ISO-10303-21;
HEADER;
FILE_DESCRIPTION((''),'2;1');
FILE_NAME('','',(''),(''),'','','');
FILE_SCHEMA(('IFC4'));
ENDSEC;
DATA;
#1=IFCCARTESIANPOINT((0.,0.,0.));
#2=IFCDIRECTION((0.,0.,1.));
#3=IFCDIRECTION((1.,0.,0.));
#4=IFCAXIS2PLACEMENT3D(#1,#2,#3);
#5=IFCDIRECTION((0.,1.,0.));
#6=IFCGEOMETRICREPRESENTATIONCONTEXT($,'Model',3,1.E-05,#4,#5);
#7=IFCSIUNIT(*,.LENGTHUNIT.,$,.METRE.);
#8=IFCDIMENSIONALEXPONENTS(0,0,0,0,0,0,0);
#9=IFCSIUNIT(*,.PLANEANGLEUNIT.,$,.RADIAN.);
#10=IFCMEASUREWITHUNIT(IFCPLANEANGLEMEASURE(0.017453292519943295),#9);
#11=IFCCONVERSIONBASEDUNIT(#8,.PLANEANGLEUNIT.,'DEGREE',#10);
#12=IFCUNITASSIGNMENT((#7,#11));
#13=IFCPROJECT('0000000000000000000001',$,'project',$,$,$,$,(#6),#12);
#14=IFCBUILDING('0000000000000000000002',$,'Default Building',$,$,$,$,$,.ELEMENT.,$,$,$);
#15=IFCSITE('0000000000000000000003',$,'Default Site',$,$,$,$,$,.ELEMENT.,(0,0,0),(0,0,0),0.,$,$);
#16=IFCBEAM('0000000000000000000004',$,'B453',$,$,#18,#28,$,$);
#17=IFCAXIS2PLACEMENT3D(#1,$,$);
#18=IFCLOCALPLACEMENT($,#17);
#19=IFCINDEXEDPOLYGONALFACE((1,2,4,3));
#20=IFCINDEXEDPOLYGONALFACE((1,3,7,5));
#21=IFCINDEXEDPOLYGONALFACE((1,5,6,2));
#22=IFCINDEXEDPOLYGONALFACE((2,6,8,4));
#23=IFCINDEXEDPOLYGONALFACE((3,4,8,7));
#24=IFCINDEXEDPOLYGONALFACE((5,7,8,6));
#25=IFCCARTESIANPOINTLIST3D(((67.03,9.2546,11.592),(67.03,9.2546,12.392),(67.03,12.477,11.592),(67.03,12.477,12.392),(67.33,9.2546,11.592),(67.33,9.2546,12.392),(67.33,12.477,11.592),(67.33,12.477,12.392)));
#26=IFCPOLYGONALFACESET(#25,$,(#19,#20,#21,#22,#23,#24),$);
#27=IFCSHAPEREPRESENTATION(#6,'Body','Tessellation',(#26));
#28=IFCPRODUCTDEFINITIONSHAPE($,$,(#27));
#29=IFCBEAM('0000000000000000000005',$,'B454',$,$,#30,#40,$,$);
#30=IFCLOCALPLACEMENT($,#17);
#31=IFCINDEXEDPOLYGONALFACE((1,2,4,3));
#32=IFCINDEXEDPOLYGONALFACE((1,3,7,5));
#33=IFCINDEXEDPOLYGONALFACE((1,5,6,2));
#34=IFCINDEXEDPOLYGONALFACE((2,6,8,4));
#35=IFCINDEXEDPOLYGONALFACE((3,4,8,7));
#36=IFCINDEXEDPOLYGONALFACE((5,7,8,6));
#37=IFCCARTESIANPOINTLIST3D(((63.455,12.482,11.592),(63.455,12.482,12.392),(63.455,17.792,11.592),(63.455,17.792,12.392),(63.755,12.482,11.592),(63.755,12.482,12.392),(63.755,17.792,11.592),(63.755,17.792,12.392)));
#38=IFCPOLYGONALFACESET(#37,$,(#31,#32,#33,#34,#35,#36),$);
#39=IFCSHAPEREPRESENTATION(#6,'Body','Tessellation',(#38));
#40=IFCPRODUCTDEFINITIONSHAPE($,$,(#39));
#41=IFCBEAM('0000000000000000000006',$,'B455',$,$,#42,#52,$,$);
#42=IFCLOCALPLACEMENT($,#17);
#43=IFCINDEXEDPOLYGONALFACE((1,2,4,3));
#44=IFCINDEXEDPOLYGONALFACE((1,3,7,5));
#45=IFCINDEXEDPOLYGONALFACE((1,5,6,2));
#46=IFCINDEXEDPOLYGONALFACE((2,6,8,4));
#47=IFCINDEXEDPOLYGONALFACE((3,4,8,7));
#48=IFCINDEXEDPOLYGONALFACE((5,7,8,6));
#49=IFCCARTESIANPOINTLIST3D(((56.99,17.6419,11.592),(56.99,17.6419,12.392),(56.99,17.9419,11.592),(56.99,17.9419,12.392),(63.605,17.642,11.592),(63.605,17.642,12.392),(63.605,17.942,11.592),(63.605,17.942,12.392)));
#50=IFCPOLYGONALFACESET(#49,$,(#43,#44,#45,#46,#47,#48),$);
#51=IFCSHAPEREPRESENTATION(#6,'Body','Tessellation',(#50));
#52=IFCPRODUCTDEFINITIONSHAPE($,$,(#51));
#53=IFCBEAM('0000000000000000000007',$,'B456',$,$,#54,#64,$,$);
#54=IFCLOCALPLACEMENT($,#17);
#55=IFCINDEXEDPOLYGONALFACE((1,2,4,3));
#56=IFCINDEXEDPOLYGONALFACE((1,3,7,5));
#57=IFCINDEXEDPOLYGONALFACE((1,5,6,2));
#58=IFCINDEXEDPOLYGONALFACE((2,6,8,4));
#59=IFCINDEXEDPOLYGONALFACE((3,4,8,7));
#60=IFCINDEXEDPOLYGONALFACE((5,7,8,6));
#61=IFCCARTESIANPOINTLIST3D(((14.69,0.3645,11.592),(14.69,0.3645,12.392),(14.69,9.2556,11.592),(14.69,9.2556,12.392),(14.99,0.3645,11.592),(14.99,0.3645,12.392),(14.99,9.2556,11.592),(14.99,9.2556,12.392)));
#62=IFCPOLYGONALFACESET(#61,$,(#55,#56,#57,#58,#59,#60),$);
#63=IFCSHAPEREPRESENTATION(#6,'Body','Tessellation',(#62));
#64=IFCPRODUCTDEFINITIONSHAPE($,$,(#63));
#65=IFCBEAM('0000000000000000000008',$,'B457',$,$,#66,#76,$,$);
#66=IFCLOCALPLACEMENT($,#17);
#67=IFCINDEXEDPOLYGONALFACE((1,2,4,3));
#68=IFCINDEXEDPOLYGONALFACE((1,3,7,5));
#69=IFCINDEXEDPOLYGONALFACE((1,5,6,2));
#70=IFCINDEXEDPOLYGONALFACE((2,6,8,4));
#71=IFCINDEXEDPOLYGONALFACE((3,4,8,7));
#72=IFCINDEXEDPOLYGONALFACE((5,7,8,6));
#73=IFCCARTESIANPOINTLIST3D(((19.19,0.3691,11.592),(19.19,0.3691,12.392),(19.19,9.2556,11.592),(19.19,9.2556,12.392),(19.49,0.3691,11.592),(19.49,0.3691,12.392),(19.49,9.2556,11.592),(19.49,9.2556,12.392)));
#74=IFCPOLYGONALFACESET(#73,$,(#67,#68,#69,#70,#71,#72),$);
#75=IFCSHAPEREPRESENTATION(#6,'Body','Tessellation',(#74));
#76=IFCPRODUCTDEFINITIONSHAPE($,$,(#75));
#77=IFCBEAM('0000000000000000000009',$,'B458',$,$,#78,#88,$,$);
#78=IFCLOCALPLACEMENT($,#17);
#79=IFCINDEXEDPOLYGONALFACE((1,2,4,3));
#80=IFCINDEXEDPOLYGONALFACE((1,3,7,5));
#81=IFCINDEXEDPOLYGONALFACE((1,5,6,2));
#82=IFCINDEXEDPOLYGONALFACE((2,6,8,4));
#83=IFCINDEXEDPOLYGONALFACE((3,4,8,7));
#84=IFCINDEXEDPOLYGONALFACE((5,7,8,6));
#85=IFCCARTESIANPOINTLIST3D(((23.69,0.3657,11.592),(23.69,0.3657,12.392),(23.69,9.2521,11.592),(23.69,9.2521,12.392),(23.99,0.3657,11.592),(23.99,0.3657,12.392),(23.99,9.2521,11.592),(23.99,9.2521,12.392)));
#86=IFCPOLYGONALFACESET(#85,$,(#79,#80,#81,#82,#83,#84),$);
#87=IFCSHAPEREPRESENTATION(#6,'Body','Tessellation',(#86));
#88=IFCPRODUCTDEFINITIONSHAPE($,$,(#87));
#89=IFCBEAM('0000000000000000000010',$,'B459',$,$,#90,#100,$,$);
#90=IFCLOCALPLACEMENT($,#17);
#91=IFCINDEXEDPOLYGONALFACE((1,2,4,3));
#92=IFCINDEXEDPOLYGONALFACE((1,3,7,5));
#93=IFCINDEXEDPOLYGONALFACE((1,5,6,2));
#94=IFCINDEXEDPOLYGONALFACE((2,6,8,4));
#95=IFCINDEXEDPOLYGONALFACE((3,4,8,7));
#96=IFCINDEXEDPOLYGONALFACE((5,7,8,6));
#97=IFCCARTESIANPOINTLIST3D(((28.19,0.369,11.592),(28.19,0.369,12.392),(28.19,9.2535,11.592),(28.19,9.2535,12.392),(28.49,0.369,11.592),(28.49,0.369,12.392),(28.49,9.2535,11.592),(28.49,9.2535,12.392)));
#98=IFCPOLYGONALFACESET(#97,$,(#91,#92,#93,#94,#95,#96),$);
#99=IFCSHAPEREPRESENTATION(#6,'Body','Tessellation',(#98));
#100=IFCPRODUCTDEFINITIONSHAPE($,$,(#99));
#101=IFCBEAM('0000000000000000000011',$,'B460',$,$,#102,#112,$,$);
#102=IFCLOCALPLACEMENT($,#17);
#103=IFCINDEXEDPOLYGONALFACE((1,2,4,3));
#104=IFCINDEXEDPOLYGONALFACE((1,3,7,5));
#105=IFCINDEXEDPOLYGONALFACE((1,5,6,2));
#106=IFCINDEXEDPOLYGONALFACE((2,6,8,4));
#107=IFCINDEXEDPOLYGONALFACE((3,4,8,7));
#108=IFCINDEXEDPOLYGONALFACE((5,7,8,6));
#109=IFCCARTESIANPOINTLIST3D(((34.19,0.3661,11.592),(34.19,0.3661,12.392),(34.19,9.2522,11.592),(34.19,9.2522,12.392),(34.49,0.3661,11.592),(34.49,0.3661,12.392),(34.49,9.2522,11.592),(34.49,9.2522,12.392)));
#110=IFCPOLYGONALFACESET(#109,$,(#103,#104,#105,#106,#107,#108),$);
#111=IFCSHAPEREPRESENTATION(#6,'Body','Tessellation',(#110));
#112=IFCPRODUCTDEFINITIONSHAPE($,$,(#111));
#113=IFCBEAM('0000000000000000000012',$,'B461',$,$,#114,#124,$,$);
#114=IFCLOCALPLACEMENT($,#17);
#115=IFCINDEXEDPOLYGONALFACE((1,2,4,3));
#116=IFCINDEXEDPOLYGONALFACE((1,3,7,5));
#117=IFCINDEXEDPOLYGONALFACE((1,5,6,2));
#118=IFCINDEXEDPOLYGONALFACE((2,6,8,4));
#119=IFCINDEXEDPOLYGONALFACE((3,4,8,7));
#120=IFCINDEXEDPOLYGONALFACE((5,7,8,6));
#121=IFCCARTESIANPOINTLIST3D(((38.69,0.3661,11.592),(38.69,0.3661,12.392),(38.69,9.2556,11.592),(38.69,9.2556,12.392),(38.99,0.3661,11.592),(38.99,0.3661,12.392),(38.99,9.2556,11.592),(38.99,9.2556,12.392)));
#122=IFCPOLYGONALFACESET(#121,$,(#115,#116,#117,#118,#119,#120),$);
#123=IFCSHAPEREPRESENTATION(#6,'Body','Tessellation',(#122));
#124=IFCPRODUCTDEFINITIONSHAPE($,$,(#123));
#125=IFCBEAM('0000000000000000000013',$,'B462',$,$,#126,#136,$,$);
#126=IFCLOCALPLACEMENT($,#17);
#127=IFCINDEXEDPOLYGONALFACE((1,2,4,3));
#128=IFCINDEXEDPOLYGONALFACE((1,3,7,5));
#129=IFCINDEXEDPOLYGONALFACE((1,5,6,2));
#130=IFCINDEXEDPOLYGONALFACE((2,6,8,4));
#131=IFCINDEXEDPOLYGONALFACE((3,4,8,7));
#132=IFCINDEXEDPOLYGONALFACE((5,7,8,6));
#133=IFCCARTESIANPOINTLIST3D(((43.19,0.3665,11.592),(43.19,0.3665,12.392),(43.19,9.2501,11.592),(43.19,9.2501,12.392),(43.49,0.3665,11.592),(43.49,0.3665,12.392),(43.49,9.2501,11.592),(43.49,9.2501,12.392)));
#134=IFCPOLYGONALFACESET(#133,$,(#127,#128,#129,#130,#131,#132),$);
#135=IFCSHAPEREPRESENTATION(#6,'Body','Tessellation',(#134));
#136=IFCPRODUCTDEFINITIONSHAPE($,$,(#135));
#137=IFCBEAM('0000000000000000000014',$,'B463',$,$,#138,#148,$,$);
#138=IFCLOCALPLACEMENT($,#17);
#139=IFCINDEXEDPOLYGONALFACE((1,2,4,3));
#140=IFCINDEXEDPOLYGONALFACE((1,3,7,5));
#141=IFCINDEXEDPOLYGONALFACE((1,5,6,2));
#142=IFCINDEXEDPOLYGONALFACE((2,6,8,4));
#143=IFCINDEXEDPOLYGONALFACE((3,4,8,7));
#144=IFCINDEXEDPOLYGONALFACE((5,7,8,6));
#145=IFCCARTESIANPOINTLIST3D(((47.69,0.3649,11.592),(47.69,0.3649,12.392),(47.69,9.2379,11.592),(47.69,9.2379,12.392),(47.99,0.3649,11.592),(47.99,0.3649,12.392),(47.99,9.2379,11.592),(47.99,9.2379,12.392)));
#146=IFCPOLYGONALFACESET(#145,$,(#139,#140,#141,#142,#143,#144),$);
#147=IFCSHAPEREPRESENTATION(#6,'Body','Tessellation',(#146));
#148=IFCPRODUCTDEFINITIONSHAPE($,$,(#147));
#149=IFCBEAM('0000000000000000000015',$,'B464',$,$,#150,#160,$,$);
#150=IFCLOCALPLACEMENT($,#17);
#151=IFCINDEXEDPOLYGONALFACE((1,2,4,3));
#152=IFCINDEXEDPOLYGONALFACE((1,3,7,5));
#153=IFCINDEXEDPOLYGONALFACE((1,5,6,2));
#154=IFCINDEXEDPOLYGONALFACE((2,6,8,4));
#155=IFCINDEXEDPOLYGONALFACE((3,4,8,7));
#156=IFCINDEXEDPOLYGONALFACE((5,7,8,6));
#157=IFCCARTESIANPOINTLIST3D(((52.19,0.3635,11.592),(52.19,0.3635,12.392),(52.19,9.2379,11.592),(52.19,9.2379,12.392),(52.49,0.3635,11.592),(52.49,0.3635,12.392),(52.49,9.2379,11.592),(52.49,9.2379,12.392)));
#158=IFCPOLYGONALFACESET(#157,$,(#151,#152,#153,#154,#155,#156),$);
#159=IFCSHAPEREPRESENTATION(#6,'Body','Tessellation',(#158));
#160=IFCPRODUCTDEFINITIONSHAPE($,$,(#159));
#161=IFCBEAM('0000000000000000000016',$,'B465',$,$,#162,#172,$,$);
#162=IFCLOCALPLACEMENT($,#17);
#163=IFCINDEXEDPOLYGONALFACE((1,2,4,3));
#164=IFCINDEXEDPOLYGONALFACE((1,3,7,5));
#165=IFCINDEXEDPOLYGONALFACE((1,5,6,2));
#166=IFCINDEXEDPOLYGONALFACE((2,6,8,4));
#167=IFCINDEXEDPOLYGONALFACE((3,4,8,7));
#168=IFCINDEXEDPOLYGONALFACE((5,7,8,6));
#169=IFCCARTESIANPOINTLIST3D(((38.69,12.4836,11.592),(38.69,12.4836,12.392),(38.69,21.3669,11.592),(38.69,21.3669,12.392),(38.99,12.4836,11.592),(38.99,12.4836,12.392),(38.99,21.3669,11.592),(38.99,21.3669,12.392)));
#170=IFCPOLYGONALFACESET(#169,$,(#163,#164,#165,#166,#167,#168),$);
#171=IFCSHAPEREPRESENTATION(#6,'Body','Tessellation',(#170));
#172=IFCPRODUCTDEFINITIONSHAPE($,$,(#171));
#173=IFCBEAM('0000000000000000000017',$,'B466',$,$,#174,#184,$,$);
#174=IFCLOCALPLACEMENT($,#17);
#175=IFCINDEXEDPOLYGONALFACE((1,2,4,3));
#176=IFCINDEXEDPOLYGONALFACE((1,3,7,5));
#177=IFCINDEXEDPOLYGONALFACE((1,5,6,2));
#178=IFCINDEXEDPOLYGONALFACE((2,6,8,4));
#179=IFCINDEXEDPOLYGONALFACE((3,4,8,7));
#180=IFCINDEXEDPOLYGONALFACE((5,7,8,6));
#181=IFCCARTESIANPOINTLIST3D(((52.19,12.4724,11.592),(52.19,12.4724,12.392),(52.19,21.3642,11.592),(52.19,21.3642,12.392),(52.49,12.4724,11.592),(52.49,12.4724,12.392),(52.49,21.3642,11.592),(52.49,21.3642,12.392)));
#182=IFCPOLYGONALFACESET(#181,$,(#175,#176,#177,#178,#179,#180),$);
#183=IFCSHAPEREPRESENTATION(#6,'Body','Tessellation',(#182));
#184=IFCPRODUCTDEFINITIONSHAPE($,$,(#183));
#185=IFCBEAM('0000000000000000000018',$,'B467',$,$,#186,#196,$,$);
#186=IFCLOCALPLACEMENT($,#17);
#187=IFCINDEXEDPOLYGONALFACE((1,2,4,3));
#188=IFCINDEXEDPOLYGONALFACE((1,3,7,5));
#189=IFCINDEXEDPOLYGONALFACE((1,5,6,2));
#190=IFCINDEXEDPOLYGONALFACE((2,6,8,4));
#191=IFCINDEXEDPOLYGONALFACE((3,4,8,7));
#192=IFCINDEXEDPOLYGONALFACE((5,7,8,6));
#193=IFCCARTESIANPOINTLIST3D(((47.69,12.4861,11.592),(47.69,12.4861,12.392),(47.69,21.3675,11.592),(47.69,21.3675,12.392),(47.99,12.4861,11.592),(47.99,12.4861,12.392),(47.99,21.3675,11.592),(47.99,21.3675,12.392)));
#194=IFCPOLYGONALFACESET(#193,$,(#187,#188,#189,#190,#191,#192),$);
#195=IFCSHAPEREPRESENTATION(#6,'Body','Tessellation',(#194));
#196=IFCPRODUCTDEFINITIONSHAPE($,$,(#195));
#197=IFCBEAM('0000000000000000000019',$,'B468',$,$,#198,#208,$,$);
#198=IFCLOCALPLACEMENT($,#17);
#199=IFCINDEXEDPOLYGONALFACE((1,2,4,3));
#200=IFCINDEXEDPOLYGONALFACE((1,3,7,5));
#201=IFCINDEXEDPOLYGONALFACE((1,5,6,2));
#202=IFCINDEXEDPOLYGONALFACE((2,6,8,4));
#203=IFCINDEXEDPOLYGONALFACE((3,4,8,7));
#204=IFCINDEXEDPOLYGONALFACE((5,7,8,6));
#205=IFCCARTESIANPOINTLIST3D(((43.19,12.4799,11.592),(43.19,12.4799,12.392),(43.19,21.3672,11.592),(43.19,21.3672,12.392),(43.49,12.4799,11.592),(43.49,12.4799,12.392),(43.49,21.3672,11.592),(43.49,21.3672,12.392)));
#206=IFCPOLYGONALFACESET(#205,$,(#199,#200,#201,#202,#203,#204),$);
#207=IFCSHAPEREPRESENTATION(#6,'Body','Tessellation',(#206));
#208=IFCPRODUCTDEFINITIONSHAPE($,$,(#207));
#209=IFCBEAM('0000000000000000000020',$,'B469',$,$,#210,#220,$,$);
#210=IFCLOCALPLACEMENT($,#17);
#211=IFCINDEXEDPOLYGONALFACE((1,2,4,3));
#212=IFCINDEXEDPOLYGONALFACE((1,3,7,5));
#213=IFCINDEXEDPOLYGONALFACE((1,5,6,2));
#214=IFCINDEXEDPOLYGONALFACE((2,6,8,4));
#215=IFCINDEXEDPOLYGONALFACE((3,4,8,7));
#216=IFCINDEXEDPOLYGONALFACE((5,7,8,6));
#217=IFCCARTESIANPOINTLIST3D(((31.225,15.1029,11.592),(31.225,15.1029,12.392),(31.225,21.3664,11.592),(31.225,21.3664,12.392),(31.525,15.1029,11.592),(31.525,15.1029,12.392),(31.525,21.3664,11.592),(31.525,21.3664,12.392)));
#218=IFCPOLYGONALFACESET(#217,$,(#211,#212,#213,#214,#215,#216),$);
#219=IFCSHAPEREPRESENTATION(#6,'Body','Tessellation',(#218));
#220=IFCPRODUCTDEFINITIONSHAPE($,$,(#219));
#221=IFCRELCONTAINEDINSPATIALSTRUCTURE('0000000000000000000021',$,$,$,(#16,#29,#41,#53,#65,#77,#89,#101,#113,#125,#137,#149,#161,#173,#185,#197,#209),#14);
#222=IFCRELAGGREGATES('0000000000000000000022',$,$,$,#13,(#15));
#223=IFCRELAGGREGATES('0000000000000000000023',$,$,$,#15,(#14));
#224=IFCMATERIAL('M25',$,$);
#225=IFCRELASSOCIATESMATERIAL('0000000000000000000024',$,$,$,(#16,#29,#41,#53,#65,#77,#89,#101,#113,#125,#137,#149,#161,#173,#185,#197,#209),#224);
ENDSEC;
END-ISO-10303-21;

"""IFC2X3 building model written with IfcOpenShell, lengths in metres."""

from ifc_helpers import new_model, entity, si_unit, converted_unit, direction, frame, frame_2d, origin_with_axes, place, context, project, spatial, rectangle, extrude, material, element, save


model = new_model("IFC2X3")

# Units and contexts
model_context = context("Model", 3, precision=1e-05, world=origin_with_axes(), true_north=direction((0.0, 1.0, 0.0)))
ifc_project = project(units=[si_unit("LENGTHUNIT", "METRE"), converted_unit("PLANEANGLEUNIT", "DEGREE", entity("IfcPlaneAngleMeasure", 0.017453292519943295), si_unit("PLANEANGLEUNIT", "RADIAN"), dimensions=[0, 0, 0, 0, 0, 0, 0])], contexts=[model_context])

# Site, building
site = spatial("IfcSite", under=ifc_project, Name="Default Site", CompositionType="ELEMENT", RefLatitude=(0, 0, 0), RefLongitude=(0, 0, 0), RefElevation=0.0)
building = spatial("IfcBuilding", under=site, Name="Default Building", CompositionType="ELEMENT")

# Beams
ifc_material = material(Name="M25")
placement = place(None, origin_with_axes())
element("IfcBeam", 1, at=placement, inside=building, material=ifc_material, Name="B453", context=model_context, shape_type="SweptSolid", body=[
    extrude(rectangle(XDim=0.3, YDim=0.8, at=frame_2d((0.0, 0.0), x_axis=(0.0, 1.0, 0.0))), frame((67.18, 9.2546, 11.992), z_axis=(0.0, 1.0, 0.0), x_axis=(0.0, 0.0, -1.0)), (0.0, 0.0, 1.0), 3.2224),
])
element("IfcBeam", 2, at=placement, inside=building, material=ifc_material, Name="B454", context=model_context, shape_type="SweptSolid", body=[
    extrude(rectangle(XDim=0.3, YDim=0.8, at=frame_2d((0.0, 0.0), x_axis=(0.0, 1.0, 0.0))), frame((63.605, 12.482, 11.992), z_axis=(0.0, 1.0, 0.0), x_axis=(0.0, 0.0, -1.0)), (0.0, 0.0, 1.0), 5.3101),
])
element("IfcBeam", 3, at=placement, inside=building, material=ifc_material, Name="B455", context=model_context, shape_type="SweptSolid", body=[
    extrude(rectangle(XDim=0.3, YDim=0.8, at=frame_2d((0.0, 0.0), x_axis=(0.0, 1.0, 0.0))), frame((56.99, 17.7919, 11.992), z_axis=(1.0, 0.00002, 0.0), x_axis=(0.0, 0.0, -1.0)), (0.0, 0.0, 1.0), 6.615),
])
element("IfcBeam", 4, at=placement, inside=building, material=ifc_material, Name="B456", context=model_context, shape_type="SweptSolid", body=[
    extrude(rectangle(XDim=0.3, YDim=0.8, at=frame_2d((0.0, 0.0), x_axis=(0.0, 1.0, 0.0))), frame((14.84, 0.3645, 11.992), z_axis=(0.0, 1.0, 0.0), x_axis=(0.0, 0.0, -1.0)), (0.0, 0.0, 1.0), 8.891),
])
element("IfcBeam", 5, at=placement, inside=building, material=ifc_material, Name="B457", context=model_context, shape_type="SweptSolid", body=[
    extrude(rectangle(XDim=0.3, YDim=0.8, at=frame_2d((0.0, 0.0), x_axis=(0.0, 1.0, 0.0))), frame((19.34, 0.3691, 11.992), z_axis=(0.0, 1.0, 0.0), x_axis=(0.0, 0.0, -1.0)), (0.0, 0.0, 1.0), 8.8865),
])
element("IfcBeam", 6, at=placement, inside=building, material=ifc_material, Name="B458", context=model_context, shape_type="SweptSolid", body=[
    extrude(rectangle(XDim=0.3, YDim=0.8, at=frame_2d((0.0, 0.0), x_axis=(0.0, 1.0, 0.0))), frame((23.84, 0.3657, 11.992), z_axis=(0.0, 1.0, 0.0), x_axis=(0.0, 0.0, -1.0)), (0.0, 0.0, 1.0), 8.8864),
])
element("IfcBeam", 7, at=placement, inside=building, material=ifc_material, Name="B459", context=model_context, shape_type="SweptSolid", body=[
    extrude(rectangle(XDim=0.3, YDim=0.8, at=frame_2d((0.0, 0.0), x_axis=(0.0, 1.0, 0.0))), frame((28.34, 0.369, 11.992), z_axis=(0.0, 1.0, 0.0), x_axis=(0.0, 0.0, -1.0)), (0.0, 0.0, 1.0), 8.8845),
])
element("IfcBeam", 8, at=placement, inside=building, material=ifc_material, Name="B460", context=model_context, shape_type="SweptSolid", body=[
    extrude(rectangle(XDim=0.3, YDim=0.8, at=frame_2d((0.0, 0.0), x_axis=(0.0, 1.0, 0.0))), frame((34.34, 0.3661, 11.992), z_axis=(0.0, 1.0, 0.0), x_axis=(0.0, 0.0, -1.0)), (0.0, 0.0, 1.0), 8.8861),
])
element("IfcBeam", 9, at=placement, inside=building, material=ifc_material, Name="B461", context=model_context, shape_type="SweptSolid", body=[
    extrude(rectangle(XDim=0.3, YDim=0.8, at=frame_2d((0.0, 0.0), x_axis=(0.0, 1.0, 0.0))), frame((38.84, 0.3661, 11.992), z_axis=(0.0, 1.0, 0.0), x_axis=(0.0, 0.0, -1.0)), (0.0, 0.0, 1.0), 8.8895),
])
element("IfcBeam", 10, at=placement, inside=building, material=ifc_material, Name="B462", context=model_context, shape_type="SweptSolid", body=[
    extrude(rectangle(XDim=0.3, YDim=0.8, at=frame_2d((0.0, 0.0), x_axis=(0.0, 1.0, 0.0))), frame((43.34, 0.3665, 11.992), z_axis=(0.0, 1.0, 0.0), x_axis=(0.0, 0.0, -1.0)), (0.0, 0.0, 1.0), 8.8836),
])
element("IfcBeam", 11, at=placement, inside=building, material=ifc_material, Name="B463", context=model_context, shape_type="SweptSolid", body=[
    extrude(rectangle(XDim=0.3, YDim=0.8, at=frame_2d((0.0, 0.0), x_axis=(0.0, 1.0, 0.0))), frame((47.84, 0.3649, 11.992), z_axis=(0.0, 1.0, 0.0), x_axis=(0.0, 0.0, -1.0)), (0.0, 0.0, 1.0), 8.873),
])
element("IfcBeam", 12, at=placement, inside=building, material=ifc_material, Name="B464", context=model_context, shape_type="SweptSolid", body=[
    extrude(rectangle(XDim=0.3, YDim=0.8, at=frame_2d((0.0, 0.0), x_axis=(0.0, 1.0, 0.0))), frame((52.34, 0.3635, 11.992), z_axis=(0.0, 1.0, 0.0), x_axis=(0.0, 0.0, -1.0)), (0.0, 0.0, 1.0), 8.8744),
])
element("IfcBeam", 13, at=placement, inside=building, material=ifc_material, Name="B465", context=model_context, shape_type="SweptSolid", body=[
    extrude(rectangle(XDim=0.3, YDim=0.8, at=frame_2d((0.0, 0.0), x_axis=(0.0, 1.0, 0.0))), frame((38.84, 21.3669, 11.992), z_axis=(0.0, -1.0, 0.0), x_axis=(0.0, 0.0, -1.0)), (0.0, 0.0, 1.0), 8.8833),
])
element("IfcBeam", 14, at=placement, inside=building, material=ifc_material, Name="B466", context=model_context, shape_type="SweptSolid", body=[
    extrude(rectangle(XDim=0.3, YDim=0.8, at=frame_2d((0.0, 0.0), x_axis=(0.0, 1.0, 0.0))), frame((52.34, 12.4724, 11.992), z_axis=(0.0, 1.0, 0.0), x_axis=(0.0, 0.0, -1.0)), (0.0, 0.0, 1.0), 8.8918),
])
element("IfcBeam", 15, at=placement, inside=building, material=ifc_material, Name="B467", context=model_context, shape_type="SweptSolid", body=[
    extrude(rectangle(XDim=0.3, YDim=0.8, at=frame_2d((0.0, 0.0), x_axis=(0.0, 1.0, 0.0))), frame((47.84, 12.4861, 11.992), z_axis=(0.0, 1.0, 0.0), x_axis=(0.0, 0.0, -1.0)), (0.0, 0.0, 1.0), 8.8814),
])
element("IfcBeam", 16, at=placement, inside=building, material=ifc_material, Name="B468", context=model_context, shape_type="SweptSolid", body=[
    extrude(rectangle(XDim=0.3, YDim=0.8, at=frame_2d((0.0, 0.0), x_axis=(0.0, 1.0, 0.0))), frame((43.34, 21.3672, 11.992), z_axis=(0.0, -1.0, 0.0), x_axis=(0.0, 0.0, -1.0)), (0.0, 0.0, 1.0), 8.8873),
])
element("IfcBeam", 17, at=placement, inside=building, material=ifc_material, Name="B469", context=model_context, shape_type="SweptSolid", body=[
    extrude(rectangle(XDim=0.3, YDim=0.8, at=frame_2d((0.0, 0.0), x_axis=(0.0, 1.0, 0.0))), frame((31.375, 21.3664, 11.992), z_axis=(0.0, -1.0, 0.0), x_axis=(0.0, 0.0, -1.0)), (0.0, 0.0, 1.0), 6.2635),
])

save(model, "model.ifc")
